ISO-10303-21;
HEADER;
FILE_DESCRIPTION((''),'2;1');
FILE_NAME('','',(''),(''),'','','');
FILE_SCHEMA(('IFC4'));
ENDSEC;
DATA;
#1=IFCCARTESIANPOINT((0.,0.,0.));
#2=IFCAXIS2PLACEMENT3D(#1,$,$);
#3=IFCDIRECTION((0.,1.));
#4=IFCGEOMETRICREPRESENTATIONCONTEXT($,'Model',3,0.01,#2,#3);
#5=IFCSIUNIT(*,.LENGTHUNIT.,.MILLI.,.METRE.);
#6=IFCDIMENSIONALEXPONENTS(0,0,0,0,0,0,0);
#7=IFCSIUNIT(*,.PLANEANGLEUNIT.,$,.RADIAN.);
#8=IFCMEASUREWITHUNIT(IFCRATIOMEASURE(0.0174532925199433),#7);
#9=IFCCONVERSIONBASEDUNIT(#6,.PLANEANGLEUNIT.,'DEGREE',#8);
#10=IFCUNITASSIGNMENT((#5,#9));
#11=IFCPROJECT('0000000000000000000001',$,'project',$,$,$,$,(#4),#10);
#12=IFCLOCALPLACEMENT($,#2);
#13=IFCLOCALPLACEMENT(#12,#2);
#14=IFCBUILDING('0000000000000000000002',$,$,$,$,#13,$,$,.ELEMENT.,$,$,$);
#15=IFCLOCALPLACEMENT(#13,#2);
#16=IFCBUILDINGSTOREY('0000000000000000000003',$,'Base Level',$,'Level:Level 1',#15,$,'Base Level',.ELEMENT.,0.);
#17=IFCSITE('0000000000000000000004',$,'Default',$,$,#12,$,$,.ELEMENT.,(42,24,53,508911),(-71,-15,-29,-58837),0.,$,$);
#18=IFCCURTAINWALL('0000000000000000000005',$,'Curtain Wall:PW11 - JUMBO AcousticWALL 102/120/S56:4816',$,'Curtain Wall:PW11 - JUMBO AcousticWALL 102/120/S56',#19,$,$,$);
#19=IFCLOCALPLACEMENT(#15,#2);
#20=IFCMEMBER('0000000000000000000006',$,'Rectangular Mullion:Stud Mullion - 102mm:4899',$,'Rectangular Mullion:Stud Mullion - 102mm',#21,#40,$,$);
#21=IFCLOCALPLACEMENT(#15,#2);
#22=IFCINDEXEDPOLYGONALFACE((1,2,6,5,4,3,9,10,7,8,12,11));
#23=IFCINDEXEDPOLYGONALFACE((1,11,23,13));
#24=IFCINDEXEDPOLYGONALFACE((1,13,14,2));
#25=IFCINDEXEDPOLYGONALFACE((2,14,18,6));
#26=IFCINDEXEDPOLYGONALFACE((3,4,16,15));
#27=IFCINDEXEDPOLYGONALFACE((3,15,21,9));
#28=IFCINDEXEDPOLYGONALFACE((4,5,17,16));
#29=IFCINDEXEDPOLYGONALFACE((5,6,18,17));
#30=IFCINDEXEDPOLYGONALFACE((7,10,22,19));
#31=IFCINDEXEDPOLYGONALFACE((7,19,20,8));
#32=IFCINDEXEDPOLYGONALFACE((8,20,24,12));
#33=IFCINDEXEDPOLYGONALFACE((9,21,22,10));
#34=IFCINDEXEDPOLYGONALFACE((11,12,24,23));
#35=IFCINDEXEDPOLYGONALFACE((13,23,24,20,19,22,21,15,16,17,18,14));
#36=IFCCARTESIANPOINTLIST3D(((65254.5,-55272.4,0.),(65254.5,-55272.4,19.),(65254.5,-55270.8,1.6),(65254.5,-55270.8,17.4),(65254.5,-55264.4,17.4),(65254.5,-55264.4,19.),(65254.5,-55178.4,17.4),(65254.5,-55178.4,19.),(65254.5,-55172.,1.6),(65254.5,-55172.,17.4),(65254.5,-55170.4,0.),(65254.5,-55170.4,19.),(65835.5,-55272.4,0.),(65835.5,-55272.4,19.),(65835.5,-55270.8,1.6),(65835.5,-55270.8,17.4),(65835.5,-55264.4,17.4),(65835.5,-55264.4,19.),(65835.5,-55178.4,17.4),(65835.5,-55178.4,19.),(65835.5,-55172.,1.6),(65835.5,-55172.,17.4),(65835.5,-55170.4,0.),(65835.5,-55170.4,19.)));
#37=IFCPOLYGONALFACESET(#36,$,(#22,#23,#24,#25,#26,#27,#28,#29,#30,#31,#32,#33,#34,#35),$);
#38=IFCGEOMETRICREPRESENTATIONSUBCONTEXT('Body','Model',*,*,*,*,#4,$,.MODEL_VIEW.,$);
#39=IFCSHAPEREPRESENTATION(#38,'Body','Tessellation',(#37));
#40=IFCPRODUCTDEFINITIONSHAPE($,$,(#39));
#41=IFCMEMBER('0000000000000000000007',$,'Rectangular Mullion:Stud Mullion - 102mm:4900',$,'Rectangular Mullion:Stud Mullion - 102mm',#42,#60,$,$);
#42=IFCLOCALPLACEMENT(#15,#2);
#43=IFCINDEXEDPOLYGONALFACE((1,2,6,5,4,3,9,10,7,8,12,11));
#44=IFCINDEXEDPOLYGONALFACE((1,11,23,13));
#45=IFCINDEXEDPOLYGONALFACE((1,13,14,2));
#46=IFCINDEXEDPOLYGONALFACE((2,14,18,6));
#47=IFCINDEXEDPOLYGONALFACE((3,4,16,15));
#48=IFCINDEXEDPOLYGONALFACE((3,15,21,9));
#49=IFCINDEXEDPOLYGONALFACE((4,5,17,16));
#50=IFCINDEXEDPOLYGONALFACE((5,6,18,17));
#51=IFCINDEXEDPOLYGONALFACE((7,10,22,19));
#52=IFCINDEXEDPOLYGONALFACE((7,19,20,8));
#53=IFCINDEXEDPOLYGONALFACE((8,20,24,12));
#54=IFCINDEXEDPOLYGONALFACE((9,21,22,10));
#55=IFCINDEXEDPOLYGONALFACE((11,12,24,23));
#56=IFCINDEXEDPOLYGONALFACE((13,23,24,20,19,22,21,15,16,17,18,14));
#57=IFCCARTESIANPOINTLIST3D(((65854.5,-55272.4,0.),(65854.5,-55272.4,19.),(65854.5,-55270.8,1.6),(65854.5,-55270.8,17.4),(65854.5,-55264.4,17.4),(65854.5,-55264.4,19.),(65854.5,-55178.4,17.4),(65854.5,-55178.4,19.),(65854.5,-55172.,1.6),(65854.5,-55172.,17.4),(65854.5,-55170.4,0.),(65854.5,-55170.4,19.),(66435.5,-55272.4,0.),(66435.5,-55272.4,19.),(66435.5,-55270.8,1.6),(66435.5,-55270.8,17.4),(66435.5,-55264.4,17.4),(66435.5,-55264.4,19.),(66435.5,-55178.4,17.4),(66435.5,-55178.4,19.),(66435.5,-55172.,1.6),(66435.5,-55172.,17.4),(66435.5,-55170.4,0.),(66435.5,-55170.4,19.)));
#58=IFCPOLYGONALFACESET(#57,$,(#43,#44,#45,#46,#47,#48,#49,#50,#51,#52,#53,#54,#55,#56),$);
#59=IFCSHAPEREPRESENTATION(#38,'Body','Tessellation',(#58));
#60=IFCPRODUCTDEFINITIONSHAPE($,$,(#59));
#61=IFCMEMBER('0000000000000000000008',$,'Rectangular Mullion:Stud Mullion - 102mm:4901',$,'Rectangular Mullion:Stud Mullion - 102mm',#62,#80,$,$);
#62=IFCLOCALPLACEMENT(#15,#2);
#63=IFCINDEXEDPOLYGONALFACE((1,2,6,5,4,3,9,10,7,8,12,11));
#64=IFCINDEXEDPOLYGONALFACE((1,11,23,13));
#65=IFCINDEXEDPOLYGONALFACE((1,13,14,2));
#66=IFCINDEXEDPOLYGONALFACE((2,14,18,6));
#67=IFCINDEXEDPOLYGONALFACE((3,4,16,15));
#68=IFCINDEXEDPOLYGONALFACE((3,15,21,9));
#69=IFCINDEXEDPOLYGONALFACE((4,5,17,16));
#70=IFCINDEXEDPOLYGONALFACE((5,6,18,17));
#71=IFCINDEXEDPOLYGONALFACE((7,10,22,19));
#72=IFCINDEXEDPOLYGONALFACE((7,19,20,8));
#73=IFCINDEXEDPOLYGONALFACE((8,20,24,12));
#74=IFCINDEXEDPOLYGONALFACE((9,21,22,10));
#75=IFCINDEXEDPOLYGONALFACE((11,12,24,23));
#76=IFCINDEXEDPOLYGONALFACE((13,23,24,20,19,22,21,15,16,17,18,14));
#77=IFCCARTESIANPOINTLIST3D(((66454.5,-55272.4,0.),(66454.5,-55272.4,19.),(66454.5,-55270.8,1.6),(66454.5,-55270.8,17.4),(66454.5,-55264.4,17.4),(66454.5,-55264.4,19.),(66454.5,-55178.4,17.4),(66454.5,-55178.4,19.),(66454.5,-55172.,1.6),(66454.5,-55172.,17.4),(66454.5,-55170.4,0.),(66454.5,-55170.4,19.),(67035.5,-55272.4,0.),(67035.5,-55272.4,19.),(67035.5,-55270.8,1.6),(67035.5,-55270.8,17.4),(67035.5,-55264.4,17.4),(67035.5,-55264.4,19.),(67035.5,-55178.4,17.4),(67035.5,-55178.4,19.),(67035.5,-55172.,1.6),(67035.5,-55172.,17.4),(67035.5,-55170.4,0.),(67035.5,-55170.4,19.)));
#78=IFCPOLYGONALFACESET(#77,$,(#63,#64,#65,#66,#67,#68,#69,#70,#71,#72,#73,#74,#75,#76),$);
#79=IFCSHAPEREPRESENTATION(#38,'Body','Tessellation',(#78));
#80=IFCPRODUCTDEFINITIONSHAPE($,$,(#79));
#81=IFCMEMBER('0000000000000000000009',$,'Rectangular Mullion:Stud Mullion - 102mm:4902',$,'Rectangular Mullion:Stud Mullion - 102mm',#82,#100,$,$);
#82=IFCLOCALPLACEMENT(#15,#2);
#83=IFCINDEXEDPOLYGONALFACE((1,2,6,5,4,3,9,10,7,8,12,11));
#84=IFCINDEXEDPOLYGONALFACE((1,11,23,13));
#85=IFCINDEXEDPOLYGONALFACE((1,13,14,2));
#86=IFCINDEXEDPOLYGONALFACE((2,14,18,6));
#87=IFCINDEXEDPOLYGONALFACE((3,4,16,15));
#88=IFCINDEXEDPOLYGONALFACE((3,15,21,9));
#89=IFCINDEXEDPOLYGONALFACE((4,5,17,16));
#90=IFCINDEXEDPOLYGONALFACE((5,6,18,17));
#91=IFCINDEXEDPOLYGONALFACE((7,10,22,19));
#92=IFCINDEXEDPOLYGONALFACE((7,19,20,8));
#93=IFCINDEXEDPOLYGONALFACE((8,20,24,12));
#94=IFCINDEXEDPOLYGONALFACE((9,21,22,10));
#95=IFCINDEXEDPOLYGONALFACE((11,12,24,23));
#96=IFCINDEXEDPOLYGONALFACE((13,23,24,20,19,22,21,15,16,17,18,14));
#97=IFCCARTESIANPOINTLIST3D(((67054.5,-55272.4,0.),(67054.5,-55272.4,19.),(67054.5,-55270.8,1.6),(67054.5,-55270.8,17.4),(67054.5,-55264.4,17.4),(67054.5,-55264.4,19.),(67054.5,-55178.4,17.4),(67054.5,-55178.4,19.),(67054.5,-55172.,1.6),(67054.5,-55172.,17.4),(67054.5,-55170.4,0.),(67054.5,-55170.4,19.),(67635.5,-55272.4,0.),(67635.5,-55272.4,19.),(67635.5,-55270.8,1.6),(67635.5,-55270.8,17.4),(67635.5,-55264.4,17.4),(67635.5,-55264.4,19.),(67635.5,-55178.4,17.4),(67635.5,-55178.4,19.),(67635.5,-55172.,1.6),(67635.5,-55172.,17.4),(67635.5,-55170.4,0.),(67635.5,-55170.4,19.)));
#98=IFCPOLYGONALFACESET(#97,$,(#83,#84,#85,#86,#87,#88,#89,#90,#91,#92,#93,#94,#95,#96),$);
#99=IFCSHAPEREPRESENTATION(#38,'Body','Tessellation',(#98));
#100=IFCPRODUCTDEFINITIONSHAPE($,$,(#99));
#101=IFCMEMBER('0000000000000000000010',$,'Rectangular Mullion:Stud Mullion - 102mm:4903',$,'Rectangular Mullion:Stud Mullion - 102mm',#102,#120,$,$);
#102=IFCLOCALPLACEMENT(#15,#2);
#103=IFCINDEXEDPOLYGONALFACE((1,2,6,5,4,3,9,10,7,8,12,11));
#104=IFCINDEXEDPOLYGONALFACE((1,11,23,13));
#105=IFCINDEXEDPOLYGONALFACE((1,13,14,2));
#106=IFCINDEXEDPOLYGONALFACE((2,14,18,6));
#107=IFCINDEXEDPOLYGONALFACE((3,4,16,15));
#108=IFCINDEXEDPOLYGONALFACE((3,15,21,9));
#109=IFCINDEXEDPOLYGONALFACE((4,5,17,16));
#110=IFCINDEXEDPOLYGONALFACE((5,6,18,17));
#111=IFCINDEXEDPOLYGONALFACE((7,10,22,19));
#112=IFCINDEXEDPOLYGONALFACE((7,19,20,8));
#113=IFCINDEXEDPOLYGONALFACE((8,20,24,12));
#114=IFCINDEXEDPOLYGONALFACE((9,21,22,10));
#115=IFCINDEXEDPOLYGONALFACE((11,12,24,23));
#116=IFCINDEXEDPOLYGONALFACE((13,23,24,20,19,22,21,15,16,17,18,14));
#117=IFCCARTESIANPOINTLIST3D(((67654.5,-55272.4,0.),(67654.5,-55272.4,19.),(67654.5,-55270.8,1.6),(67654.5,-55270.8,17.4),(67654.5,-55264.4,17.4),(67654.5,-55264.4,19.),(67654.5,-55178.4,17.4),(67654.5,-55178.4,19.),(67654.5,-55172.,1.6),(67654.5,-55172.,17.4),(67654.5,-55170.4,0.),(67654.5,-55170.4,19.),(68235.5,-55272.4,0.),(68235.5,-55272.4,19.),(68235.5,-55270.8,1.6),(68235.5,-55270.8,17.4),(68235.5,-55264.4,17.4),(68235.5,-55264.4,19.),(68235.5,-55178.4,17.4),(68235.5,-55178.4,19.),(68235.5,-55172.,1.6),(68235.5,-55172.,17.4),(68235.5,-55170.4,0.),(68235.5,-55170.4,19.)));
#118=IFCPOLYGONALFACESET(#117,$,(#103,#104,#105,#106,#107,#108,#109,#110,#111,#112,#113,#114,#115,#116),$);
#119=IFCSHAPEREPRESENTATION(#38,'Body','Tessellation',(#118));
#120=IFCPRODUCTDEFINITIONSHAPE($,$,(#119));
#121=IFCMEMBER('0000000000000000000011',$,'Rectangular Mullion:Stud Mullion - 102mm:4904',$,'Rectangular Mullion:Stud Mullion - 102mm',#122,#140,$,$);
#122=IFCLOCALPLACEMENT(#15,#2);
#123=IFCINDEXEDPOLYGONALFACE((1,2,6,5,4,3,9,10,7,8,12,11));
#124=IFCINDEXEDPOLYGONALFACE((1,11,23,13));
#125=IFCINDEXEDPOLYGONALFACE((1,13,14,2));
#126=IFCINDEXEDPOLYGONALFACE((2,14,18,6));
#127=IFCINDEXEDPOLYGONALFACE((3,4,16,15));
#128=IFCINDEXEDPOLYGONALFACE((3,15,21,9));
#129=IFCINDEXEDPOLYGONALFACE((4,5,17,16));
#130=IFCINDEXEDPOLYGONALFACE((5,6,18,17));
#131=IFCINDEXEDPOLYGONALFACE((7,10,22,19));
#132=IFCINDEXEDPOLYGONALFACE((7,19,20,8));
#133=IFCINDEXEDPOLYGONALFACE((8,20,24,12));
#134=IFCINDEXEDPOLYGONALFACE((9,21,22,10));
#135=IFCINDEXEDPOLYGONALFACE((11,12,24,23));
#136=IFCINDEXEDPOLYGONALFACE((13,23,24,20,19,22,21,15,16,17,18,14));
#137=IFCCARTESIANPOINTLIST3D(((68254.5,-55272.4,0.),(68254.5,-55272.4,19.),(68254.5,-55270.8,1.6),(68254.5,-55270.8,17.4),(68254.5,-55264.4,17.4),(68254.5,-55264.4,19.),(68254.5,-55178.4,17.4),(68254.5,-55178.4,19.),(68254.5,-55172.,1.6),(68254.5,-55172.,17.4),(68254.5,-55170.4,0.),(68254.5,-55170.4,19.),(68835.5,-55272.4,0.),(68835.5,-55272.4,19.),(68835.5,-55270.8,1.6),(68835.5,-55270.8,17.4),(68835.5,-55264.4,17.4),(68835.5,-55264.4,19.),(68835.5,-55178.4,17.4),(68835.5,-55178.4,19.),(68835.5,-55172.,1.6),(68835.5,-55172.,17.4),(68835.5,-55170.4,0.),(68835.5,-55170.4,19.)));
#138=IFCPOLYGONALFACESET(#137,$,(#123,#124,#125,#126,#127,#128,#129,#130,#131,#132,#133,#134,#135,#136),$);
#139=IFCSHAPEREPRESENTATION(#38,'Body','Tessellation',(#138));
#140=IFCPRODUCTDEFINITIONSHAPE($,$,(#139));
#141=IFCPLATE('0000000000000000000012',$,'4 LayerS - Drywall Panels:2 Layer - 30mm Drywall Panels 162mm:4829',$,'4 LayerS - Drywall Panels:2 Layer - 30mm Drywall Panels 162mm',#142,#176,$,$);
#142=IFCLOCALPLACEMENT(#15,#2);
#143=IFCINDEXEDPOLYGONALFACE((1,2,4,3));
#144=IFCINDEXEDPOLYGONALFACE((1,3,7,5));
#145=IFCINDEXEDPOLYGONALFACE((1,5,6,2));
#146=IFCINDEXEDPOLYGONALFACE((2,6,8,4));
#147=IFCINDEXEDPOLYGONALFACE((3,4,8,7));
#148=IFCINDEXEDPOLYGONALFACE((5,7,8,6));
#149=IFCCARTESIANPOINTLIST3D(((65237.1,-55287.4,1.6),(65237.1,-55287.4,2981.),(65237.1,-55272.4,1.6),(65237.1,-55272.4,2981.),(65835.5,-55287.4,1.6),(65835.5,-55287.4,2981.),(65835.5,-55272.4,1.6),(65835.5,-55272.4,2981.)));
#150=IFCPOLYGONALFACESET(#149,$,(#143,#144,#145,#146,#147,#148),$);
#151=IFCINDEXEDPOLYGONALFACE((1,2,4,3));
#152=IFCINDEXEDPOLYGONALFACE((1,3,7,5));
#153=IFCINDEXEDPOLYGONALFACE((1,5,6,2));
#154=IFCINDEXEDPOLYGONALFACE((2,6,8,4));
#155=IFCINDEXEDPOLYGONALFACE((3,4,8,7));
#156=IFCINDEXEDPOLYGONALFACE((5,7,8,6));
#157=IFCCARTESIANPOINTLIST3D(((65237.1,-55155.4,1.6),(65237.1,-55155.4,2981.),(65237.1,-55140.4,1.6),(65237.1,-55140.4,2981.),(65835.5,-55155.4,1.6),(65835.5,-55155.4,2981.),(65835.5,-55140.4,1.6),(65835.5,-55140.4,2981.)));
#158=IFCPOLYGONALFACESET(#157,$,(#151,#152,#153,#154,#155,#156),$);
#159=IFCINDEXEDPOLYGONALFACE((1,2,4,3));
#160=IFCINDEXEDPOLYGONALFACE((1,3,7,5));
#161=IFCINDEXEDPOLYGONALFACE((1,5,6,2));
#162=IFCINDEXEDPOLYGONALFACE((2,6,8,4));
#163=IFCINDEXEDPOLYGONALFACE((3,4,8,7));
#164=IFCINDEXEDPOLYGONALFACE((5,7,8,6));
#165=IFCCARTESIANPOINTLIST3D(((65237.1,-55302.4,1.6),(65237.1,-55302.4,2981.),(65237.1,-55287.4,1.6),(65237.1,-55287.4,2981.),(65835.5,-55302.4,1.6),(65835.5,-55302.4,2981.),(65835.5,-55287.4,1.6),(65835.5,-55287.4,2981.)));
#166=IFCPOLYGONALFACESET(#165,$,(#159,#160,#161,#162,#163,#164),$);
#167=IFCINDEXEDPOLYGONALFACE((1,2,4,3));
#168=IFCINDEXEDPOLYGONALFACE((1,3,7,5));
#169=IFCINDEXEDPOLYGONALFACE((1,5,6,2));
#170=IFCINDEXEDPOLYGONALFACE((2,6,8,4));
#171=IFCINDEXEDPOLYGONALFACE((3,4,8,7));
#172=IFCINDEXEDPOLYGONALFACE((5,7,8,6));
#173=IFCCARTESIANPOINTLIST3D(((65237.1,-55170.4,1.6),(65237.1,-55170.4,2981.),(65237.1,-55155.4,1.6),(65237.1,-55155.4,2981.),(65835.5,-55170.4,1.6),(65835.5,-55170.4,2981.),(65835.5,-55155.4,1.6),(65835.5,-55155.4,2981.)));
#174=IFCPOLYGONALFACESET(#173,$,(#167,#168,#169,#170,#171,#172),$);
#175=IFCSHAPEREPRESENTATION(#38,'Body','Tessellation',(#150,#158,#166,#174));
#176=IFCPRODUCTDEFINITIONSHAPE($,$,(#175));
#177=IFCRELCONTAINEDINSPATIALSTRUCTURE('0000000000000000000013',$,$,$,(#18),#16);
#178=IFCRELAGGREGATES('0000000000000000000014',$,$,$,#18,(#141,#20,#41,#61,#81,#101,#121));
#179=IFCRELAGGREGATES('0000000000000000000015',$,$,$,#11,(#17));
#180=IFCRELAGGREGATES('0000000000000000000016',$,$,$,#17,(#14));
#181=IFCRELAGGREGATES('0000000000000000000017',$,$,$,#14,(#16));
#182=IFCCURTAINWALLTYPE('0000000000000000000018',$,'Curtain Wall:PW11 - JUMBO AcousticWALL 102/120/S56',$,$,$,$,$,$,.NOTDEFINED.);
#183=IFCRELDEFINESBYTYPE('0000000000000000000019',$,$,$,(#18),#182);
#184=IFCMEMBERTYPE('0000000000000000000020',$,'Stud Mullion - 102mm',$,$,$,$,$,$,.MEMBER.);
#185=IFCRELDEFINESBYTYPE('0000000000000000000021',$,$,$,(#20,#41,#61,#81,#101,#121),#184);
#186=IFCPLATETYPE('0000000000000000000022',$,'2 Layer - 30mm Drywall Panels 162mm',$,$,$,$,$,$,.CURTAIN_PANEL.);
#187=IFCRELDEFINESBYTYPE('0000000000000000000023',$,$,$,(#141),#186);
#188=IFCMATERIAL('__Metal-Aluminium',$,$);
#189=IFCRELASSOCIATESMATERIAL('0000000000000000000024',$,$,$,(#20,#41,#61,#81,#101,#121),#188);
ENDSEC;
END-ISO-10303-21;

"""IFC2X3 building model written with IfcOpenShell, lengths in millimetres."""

from ifc_helpers import new_model, entity, si_unit, converted_unit, direction, frame, frame_2d, origin, origin_2d_with_axis, place, context, subcontext, project, spatial, polyline, rectangle, outline, extrude, source, transform, mapped, material, type_object, type_shapes, element, aggregate, save


model = new_model("IFC2X3")

# Units and contexts
model_context = context("Model", 3, precision=0.01, world=origin(), true_north=direction((0.0, 1.0)))
body_context = subcontext(model_context, "Body", "Model", "MODEL_VIEW")
ifc_project = project(units=[si_unit("LENGTHUNIT", "METRE", prefix="MILLI"), converted_unit("PLANEANGLEUNIT", "DEGREE", entity("IfcRatioMeasure", 0.0174532925199433), si_unit("PLANEANGLEUNIT", "RADIAN"), dimensions=[0, 0, 0, 0, 0, 0, 0])], contexts=[model_context])

# Site, building, storey
site_placement = place(None, origin())
site = spatial("IfcSite", under=ifc_project, at=site_placement, Name="Default", CompositionType="ELEMENT", RefLatitude=(42, 24, 53, 508911), RefLongitude=(-71, -15, -29, -58837), RefElevation=0.0)
building_placement = place(site_placement, origin())
building = spatial("IfcBuilding", under=site, at=building_placement, CompositionType="ELEMENT")
storey_placement = place(building_placement, origin())
storey = spatial("IfcBuildingStorey", under=building, at=storey_placement, Name="Base Level", ObjectType="Level:Level 1", LongName="Base Level", CompositionType="ELEMENT", Elevation=0.0)

# Curtain wall, members, plate
curtain_wall_type = type_object("IfcCurtainWallType", Name="Curtain Wall:PW11 - JUMBO AcousticWALL 102/120/S56", PredefinedType="NOTDEFINED")
curtain_wall_placement = place(building_placement, origin())
curtain_wall = element("IfcCurtainWall", 1, at=curtain_wall_placement, inside=storey, type_object=curtain_wall_type, Name="Curtain Wall:PW11 - JUMBO AcousticWALL 102/120/S56:4816", ObjectType="Curtain Wall:PW11 - JUMBO AcousticWALL 102/120/S56")
ifc_material = material(Name="__Metal-Aluminium")
member_type_1 = type_object("IfcMemberType", Name="Stud Mullion - 102mm", PredefinedType="MEMBER")
shared_shape_1 = source(origin(), body_context, "Body", "SweptSolid", [
    extrude(outline(polyline([(43.0, -6.6), (51.0, -6.6), (51.0, 12.4), (-51.0, 12.4), (-51.0, -6.6), (-43.0, -6.6), (-43.0, -5.0), (-49.4, -5.0), (-49.4, 10.8), (49.4, 10.8), (49.4, -5.0), (43.0, -5.0), (43.0, -6.6)])), frame((-12.4, 0.0, -581.0), z_axis=(0.0, 0.0, 1.0), x_axis=(0.0, -1.0, 0.0)), (0.0, 0.0, 1.0), 581.0),
])
type_shapes(member_type_1, [shared_shape_1])
member_1_placement = place(building_placement, frame((65254.5, -55221.4, 0.0), z_axis=(-1.0, 0.0, 0.0), x_axis=(0.0, 0.0, -1.0)))
member_1 = element("IfcMember", 2, at=member_1_placement, type_object=member_type_1, material=ifc_material, Name="Rectangular Mullion:Stud Mullion - 102mm:4899", ObjectType="Rectangular Mullion:Stud Mullion - 102mm", context=body_context, shape_type="MappedRepresentation", body=[
    mapped(shared_shape_1, transform((0.0, 0.0, 0.0), scale=1.0)),
])
member_2_placement = place(building_placement, frame((65854.5, -55221.4, 0.0), z_axis=(-1.0, 0.0, 0.0), x_axis=(0.0, 0.0, -1.0)))
member_2 = element("IfcMember", 3, at=member_2_placement, type_object=member_type_1, material=ifc_material, Name="Rectangular Mullion:Stud Mullion - 102mm:4900", ObjectType="Rectangular Mullion:Stud Mullion - 102mm", context=body_context, shape_type="MappedRepresentation", body=[
    mapped(shared_shape_1, transform((0.0, 0.0, 0.0), scale=1.0)),
])
member_3_placement = place(building_placement, frame((66454.5, -55221.4, 0.0), z_axis=(-1.0, 0.0, 0.0), x_axis=(0.0, 0.0, -1.0)))
member_3 = element("IfcMember", 4, at=member_3_placement, type_object=member_type_1, material=ifc_material, Name="Rectangular Mullion:Stud Mullion - 102mm:4901", ObjectType="Rectangular Mullion:Stud Mullion - 102mm", context=body_context, shape_type="MappedRepresentation", body=[
    mapped(shared_shape_1, transform((0.0, 0.0, 0.0), scale=1.0)),
])
member_4_placement = place(building_placement, frame((67054.5, -55221.4, 0.0), z_axis=(-1.0, 0.0, 0.0), x_axis=(0.0, 0.0, -1.0)))
member_4 = element("IfcMember", 5, at=member_4_placement, type_object=member_type_1, material=ifc_material, Name="Rectangular Mullion:Stud Mullion - 102mm:4902", ObjectType="Rectangular Mullion:Stud Mullion - 102mm", context=body_context, shape_type="MappedRepresentation", body=[
    mapped(shared_shape_1, transform((0.0, 0.0, 0.0), scale=1.0)),
])
member_5_placement = place(building_placement, frame((67654.5, -55221.4, 0.0), z_axis=(-1.0, 0.0, 0.0), x_axis=(0.0, 0.0, -1.0)))
member_5 = element("IfcMember", 6, at=member_5_placement, type_object=member_type_1, material=ifc_material, Name="Rectangular Mullion:Stud Mullion - 102mm:4903", ObjectType="Rectangular Mullion:Stud Mullion - 102mm", context=body_context, shape_type="MappedRepresentation", body=[
    mapped(shared_shape_1, transform((0.0, 0.0, 0.0), scale=1.0)),
])
member_6_placement = place(building_placement, frame((68254.5, -55221.4, 0.0), z_axis=(-1.0, 0.0, 0.0), x_axis=(0.0, 0.0, -1.0)))
member_6 = element("IfcMember", 7, at=member_6_placement, type_object=member_type_1, material=ifc_material, Name="Rectangular Mullion:Stud Mullion - 102mm:4904", ObjectType="Rectangular Mullion:Stud Mullion - 102mm", context=body_context, shape_type="MappedRepresentation", body=[
    mapped(shared_shape_1, transform((0.0, 0.0, 0.0), scale=1.0)),
])
plate_type = type_object("IfcPlateType", Name="2 Layer - 30mm Drywall Panels 162mm", PredefinedType="CURTAIN_PANEL")
shared_shape_2 = source(origin(), body_context, "Body", "SweptSolid", [
    extrude(rectangle(XDim=15.0, YDim=598.4, at=origin_2d_with_axis()), frame((0.0, -58.5, 0.0), z_axis=(0.0, 0.0, 1.0), x_axis=(0.0, 1.0, 0.0)), (0.0, 0.0, 1.0), 2979.4),
    extrude(rectangle(XDim=15.0, YDim=598.4, at=frame_2d((0.0, 0.0), x_axis=(1.0, 0.0))), frame((0.0, 73.5, 0.0), z_axis=(0.0, 0.0, 1.0), x_axis=(0.0, 1.0, 0.0)), (0.0, 0.0, 1.0), 2979.4),
    extrude(rectangle(XDim=598.4, YDim=15.0, at=origin_2d_with_axis()), frame((0.0, -73.5, 0.0), z_axis=(0.0, 0.0, 1.0), x_axis=(-1.0, 0.0, 0.0)), (0.0, 0.0, 1.0), 2979.4),
    extrude(rectangle(XDim=15.0, YDim=598.4, at=frame_2d((0.0, 0.0), x_axis=(1.0, 0.0))), frame((0.0, 58.5, 0.0), z_axis=(0.0, 0.0, 1.0), x_axis=(0.0, 1.0, 0.0)), (0.0, 0.0, 1.0), 2979.4),
])
type_shapes(plate_type, [shared_shape_2])
plate_1_placement = place(curtain_wall_placement, frame((65536.3, -55221.4, 1.6)))
plate_1 = element("IfcPlate", 8, at=plate_1_placement, type_object=plate_type, Name="4 LayerS - Drywall Panels:2 Layer - 30mm Drywall Panels 162mm:4829", ObjectType="4 LayerS - Drywall Panels:2 Layer - 30mm Drywall Panels 162mm", context=body_context, shape_type="MappedRepresentation", body=[
    mapped(shared_shape_2, transform((0.0, 0.0, 0.0), scale=1.0)),
])
aggregate(curtain_wall, [plate_1, member_1, member_2, member_3, member_4, member_5, member_6])

save(model, "model.ifc")
